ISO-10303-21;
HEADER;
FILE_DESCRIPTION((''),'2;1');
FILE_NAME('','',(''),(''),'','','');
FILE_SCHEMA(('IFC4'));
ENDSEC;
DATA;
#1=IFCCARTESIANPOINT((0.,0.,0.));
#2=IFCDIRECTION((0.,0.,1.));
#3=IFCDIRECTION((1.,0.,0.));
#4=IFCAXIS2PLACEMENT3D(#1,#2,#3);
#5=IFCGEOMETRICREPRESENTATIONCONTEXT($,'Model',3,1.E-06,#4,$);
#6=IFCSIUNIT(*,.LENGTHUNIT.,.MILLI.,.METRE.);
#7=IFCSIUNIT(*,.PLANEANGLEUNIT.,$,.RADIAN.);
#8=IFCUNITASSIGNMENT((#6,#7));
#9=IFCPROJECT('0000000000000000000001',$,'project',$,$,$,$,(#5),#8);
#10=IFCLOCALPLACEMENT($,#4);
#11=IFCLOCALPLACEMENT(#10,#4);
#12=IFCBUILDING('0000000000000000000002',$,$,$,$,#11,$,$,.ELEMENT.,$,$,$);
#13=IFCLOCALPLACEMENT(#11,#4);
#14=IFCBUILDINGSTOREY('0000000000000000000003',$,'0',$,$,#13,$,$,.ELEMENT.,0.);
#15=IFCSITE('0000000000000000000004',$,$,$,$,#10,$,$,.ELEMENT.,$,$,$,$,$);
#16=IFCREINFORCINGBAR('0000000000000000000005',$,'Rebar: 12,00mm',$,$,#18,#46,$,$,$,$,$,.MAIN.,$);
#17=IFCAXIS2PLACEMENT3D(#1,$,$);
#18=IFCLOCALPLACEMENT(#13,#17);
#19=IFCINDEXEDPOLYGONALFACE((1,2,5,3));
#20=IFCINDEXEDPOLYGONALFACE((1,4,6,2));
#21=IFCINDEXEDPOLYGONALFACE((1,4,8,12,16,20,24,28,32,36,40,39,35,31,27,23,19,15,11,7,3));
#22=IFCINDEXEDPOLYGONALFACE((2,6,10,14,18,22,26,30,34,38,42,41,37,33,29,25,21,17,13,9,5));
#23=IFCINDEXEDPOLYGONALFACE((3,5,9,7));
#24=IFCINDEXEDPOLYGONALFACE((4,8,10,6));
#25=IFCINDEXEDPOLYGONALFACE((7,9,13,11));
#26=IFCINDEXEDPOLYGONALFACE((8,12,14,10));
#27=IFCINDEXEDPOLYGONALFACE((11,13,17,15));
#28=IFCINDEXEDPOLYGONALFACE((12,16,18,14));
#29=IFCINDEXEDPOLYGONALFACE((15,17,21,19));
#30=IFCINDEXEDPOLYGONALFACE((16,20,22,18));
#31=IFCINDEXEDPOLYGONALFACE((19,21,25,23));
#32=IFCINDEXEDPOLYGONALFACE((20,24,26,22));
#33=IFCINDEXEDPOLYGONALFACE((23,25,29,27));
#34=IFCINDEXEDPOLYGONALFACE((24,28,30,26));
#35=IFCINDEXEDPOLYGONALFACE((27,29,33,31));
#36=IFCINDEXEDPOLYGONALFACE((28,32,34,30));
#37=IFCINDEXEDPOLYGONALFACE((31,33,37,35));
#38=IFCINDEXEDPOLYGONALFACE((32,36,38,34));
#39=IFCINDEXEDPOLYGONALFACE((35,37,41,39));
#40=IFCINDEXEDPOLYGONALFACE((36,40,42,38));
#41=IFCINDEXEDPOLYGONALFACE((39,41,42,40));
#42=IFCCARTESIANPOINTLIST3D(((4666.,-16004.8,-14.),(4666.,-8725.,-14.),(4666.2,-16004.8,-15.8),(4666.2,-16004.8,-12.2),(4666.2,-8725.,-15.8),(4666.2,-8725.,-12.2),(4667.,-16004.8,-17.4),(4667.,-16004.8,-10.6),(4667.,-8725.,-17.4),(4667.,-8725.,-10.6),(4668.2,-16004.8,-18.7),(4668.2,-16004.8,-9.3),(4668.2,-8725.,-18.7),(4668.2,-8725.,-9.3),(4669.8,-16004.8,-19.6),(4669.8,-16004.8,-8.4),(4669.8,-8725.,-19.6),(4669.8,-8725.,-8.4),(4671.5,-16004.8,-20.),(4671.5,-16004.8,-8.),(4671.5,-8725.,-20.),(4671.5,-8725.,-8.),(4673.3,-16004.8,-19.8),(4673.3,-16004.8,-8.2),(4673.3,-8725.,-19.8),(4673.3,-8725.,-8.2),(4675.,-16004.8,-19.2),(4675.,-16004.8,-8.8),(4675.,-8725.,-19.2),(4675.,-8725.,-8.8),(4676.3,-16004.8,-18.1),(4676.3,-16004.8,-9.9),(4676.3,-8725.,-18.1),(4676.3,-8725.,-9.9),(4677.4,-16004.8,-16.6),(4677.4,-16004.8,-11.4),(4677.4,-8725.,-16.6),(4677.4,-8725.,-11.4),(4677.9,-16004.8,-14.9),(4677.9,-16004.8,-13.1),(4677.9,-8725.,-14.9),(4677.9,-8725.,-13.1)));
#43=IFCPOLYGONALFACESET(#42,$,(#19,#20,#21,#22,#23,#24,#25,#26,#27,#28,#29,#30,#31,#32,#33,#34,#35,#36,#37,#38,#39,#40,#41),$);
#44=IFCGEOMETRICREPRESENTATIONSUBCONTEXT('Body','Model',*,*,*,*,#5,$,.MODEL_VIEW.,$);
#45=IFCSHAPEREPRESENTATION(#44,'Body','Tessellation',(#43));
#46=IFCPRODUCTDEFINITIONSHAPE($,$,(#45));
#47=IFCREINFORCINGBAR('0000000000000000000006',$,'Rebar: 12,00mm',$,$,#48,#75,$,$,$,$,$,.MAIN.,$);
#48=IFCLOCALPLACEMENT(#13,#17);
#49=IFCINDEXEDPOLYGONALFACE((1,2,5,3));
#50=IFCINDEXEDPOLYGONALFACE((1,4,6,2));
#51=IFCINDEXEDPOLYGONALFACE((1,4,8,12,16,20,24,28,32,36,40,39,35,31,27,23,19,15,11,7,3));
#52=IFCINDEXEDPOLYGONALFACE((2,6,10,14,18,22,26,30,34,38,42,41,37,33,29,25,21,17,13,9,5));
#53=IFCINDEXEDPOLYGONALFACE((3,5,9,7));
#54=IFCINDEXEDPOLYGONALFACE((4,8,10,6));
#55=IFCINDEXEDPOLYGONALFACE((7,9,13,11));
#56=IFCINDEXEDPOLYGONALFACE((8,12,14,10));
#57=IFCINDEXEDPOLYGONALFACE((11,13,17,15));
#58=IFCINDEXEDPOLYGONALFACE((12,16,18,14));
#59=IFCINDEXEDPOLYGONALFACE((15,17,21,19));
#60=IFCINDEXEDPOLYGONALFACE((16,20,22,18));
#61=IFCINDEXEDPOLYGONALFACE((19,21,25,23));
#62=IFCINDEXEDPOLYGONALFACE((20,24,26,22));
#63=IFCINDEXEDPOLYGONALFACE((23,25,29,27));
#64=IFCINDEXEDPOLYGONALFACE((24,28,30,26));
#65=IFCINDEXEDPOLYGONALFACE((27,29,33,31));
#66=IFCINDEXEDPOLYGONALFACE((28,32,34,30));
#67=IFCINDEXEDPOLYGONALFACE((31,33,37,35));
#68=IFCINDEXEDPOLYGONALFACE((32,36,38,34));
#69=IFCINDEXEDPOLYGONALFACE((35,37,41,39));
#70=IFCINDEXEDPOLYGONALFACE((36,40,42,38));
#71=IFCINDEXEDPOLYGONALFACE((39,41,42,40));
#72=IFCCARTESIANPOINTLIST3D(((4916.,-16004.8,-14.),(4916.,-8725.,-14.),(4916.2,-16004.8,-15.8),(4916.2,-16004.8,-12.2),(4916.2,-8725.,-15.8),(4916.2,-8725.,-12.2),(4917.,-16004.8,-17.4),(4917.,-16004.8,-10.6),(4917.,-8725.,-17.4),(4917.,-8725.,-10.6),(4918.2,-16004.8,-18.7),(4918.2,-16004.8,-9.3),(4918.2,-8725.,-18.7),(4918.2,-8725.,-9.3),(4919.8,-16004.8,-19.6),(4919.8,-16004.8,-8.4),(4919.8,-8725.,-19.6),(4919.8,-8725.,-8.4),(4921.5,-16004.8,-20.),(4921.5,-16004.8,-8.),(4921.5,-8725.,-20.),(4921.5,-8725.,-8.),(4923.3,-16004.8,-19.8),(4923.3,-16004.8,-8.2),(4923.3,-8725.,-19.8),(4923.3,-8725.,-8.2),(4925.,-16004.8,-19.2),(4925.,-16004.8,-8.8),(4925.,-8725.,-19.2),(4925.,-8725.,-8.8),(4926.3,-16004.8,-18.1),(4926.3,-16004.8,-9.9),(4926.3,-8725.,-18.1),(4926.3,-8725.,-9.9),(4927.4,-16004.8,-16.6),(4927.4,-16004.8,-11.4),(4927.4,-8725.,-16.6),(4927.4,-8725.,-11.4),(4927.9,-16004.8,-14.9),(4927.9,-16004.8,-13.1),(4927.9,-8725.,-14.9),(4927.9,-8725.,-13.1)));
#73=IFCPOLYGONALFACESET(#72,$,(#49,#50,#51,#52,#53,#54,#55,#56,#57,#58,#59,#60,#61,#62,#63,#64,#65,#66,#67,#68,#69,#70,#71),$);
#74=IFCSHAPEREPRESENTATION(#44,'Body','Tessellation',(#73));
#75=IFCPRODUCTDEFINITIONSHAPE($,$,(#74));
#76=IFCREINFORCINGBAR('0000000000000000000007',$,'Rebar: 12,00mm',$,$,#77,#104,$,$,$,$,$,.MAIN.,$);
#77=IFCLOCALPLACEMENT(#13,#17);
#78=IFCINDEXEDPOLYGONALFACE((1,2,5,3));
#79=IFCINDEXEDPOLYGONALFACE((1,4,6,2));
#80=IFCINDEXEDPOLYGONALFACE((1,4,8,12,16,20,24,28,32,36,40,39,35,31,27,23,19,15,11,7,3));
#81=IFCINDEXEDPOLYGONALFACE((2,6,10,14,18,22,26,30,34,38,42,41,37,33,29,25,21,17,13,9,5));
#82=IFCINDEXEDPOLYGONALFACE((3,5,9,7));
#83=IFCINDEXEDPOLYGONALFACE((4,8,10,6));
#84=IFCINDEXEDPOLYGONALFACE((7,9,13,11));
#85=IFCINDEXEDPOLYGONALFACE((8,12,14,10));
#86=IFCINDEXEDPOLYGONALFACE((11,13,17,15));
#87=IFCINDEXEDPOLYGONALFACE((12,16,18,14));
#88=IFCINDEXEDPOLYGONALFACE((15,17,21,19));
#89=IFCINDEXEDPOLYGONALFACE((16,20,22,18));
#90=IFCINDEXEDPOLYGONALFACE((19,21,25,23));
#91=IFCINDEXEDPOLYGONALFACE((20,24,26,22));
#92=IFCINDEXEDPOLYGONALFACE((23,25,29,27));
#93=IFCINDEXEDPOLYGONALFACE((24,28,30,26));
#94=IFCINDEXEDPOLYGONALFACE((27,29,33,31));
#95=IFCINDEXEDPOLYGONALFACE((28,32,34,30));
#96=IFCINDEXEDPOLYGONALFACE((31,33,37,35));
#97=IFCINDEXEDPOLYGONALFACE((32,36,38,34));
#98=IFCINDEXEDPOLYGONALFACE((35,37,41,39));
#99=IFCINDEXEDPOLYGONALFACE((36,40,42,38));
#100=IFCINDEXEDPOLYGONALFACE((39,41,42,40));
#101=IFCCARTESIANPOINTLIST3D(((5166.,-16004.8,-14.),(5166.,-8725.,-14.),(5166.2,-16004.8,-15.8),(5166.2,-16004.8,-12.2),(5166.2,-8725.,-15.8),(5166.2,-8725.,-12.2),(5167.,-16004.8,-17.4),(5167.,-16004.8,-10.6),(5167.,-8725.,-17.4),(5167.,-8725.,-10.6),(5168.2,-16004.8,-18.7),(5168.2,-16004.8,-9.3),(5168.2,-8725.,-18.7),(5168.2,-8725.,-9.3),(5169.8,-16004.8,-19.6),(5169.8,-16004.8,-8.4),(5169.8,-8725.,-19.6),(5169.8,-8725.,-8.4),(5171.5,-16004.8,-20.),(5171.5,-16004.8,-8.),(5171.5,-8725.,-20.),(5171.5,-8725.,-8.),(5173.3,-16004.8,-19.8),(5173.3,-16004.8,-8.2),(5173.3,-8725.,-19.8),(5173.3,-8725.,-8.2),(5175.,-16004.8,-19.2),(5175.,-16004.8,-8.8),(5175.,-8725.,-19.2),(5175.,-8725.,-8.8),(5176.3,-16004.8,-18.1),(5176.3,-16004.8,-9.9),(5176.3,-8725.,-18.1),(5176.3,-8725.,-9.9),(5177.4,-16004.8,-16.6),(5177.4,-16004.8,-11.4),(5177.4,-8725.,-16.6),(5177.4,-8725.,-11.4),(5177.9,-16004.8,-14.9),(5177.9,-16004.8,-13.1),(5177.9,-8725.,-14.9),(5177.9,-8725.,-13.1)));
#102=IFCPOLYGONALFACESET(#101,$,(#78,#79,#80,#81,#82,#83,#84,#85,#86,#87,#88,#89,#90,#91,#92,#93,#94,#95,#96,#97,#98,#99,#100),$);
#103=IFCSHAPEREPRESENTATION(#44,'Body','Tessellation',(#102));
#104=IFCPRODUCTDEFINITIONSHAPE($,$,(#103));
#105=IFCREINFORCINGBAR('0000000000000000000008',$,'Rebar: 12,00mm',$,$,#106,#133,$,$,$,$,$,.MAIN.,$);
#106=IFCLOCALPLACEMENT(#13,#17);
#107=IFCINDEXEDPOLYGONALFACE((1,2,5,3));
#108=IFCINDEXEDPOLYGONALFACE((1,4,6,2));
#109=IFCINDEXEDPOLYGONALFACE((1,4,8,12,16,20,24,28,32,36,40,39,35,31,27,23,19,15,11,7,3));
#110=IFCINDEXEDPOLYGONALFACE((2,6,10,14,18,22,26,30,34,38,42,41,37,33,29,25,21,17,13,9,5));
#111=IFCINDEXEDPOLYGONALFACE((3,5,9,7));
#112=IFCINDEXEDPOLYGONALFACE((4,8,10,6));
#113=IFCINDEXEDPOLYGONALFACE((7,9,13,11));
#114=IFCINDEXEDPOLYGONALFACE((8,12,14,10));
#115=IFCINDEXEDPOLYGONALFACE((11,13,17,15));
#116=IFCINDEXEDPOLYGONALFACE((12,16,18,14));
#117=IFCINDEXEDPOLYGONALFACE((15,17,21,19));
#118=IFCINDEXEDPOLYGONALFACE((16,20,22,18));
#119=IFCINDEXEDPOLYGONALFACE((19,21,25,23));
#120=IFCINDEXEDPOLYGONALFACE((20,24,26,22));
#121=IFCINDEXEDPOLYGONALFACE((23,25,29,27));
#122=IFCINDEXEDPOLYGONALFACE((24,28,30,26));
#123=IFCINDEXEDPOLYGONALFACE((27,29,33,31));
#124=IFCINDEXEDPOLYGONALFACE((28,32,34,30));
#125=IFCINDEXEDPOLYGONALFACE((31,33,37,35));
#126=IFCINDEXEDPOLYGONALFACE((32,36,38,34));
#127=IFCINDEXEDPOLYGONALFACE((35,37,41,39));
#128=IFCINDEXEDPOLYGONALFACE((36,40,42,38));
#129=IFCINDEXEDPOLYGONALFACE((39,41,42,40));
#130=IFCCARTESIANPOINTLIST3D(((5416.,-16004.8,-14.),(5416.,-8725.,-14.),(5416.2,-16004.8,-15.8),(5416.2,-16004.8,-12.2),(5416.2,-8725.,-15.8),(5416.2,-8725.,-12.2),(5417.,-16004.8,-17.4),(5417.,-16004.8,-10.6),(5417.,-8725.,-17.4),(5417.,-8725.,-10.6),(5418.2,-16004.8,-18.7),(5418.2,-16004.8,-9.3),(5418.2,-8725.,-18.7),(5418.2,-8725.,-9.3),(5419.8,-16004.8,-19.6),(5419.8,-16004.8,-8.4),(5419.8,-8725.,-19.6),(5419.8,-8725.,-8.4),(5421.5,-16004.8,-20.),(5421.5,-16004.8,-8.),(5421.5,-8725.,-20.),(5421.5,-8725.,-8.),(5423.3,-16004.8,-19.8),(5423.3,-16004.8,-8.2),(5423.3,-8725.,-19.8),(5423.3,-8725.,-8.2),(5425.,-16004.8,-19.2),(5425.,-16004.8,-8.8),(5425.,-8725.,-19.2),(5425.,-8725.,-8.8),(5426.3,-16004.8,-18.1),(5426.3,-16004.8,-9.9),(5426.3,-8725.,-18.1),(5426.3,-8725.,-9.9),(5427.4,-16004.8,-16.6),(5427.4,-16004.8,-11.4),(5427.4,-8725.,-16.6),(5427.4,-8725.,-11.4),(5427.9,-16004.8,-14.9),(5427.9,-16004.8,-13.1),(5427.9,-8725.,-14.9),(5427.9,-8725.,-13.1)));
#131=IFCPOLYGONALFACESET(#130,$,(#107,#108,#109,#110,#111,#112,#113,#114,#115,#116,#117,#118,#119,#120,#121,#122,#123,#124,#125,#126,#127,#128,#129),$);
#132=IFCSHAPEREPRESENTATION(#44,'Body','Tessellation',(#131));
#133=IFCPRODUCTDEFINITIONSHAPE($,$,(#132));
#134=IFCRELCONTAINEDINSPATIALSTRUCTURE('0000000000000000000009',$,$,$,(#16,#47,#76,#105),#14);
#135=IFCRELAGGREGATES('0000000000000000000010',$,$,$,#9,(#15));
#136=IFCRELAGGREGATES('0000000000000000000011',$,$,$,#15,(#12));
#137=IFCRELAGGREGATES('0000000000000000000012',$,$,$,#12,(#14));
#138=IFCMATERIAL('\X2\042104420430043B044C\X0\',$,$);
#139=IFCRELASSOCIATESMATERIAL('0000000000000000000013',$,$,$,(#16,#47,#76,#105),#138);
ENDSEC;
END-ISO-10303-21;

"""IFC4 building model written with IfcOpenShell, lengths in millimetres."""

from ifc_helpers import new_model, entity, si_unit, origin_with_axes, place, context, subcontext, project, spatial, source, transform, mapped, material, element, save


model = new_model("IFC4")

# Units and contexts
model_context = context("Model", 3, precision=1e-06, world=origin_with_axes())
body_context = subcontext(model_context, "Body", "Model", "MODEL_VIEW")
ifc_project = project(units=[si_unit("LENGTHUNIT", "METRE", prefix="MILLI"), si_unit("PLANEANGLEUNIT", "RADIAN")], contexts=[model_context])

# Site, building, storey
site_placement = place(None, origin_with_axes())
site = spatial("IfcSite", under=ifc_project, at=site_placement, CompositionType="ELEMENT")
building_placement = place(site_placement, origin_with_axes())
building = spatial("IfcBuilding", under=site, at=building_placement, CompositionType="ELEMENT")
storey_placement = place(building_placement, origin_with_axes())
storey = spatial("IfcBuildingStorey", under=building, at=storey_placement, Name="0", CompositionType="ELEMENT", Elevation=0.0)

# Reinforcing bars
ifc_material = material(Name="Сталь")
shared_shape = source(origin_with_axes(), body_context, "Body", "AdvancedSweptSolid", [
    entity("IfcSweptDiskSolid", entity("IfcIndexedPolyCurve", entity("IfcCartesianPointList3D", [[0.0, 0.0, 0.0], [7279.8, 0.0, 0.0]]), [entity("IfcLineIndex", [1, 2])]), 6.0),
])
reinforcing_bar_1_placement = place(storey_placement, origin_with_axes())
element("IfcReinforcingBar", 1, at=reinforcing_bar_1_placement, inside=storey, material=ifc_material, Name="Rebar: 12,00mm", PredefinedType="MAIN", context=body_context, shape_type="MappedRepresentation", body=[
    mapped(shared_shape, transform((4672.0, -16004.8, -14.0), x_axis=(0.0, 1.0, 0.0), y_axis=(-1.0, 0.0, 0.0), z_axis=(0.0, 0.0, 1.0), scale=1.0)),
])
reinforcing_bar_2_placement = place(storey_placement, origin_with_axes())
element("IfcReinforcingBar", 2, at=reinforcing_bar_2_placement, inside=storey, material=ifc_material, Name="Rebar: 12,00mm", PredefinedType="MAIN", context=body_context, shape_type="MappedRepresentation", body=[
    mapped(shared_shape, transform((4922.0, -16004.8, -14.0), x_axis=(0.0, 1.0, 0.0), y_axis=(-1.0, 0.0, 0.0), z_axis=(0.0, 0.0, 1.0), scale=1.0)),
])
reinforcing_bar_3_placement = place(storey_placement, origin_with_axes())
element("IfcReinforcingBar", 3, at=reinforcing_bar_3_placement, inside=storey, material=ifc_material, Name="Rebar: 12,00mm", PredefinedType="MAIN", context=body_context, shape_type="MappedRepresentation", body=[
    mapped(shared_shape, transform((5172.0, -16004.8, -14.0), x_axis=(0.0, 1.0, 0.0), y_axis=(-1.0, 0.0, 0.0), z_axis=(0.0, 0.0, 1.0), scale=1.0)),
])
reinforcing_bar_4_placement = place(storey_placement, origin_with_axes())
element("IfcReinforcingBar", 4, at=reinforcing_bar_4_placement, inside=storey, material=ifc_material, Name="Rebar: 12,00mm", PredefinedType="MAIN", context=body_context, shape_type="MappedRepresentation", body=[
    mapped(shared_shape, transform((5422.0, -16004.8, -14.0), x_axis=(0.0, 1.0, 0.0), y_axis=(-1.0, 0.0, 0.0), z_axis=(0.0, 0.0, 1.0), scale=1.0)),
])

save(model, "model.ifc")
